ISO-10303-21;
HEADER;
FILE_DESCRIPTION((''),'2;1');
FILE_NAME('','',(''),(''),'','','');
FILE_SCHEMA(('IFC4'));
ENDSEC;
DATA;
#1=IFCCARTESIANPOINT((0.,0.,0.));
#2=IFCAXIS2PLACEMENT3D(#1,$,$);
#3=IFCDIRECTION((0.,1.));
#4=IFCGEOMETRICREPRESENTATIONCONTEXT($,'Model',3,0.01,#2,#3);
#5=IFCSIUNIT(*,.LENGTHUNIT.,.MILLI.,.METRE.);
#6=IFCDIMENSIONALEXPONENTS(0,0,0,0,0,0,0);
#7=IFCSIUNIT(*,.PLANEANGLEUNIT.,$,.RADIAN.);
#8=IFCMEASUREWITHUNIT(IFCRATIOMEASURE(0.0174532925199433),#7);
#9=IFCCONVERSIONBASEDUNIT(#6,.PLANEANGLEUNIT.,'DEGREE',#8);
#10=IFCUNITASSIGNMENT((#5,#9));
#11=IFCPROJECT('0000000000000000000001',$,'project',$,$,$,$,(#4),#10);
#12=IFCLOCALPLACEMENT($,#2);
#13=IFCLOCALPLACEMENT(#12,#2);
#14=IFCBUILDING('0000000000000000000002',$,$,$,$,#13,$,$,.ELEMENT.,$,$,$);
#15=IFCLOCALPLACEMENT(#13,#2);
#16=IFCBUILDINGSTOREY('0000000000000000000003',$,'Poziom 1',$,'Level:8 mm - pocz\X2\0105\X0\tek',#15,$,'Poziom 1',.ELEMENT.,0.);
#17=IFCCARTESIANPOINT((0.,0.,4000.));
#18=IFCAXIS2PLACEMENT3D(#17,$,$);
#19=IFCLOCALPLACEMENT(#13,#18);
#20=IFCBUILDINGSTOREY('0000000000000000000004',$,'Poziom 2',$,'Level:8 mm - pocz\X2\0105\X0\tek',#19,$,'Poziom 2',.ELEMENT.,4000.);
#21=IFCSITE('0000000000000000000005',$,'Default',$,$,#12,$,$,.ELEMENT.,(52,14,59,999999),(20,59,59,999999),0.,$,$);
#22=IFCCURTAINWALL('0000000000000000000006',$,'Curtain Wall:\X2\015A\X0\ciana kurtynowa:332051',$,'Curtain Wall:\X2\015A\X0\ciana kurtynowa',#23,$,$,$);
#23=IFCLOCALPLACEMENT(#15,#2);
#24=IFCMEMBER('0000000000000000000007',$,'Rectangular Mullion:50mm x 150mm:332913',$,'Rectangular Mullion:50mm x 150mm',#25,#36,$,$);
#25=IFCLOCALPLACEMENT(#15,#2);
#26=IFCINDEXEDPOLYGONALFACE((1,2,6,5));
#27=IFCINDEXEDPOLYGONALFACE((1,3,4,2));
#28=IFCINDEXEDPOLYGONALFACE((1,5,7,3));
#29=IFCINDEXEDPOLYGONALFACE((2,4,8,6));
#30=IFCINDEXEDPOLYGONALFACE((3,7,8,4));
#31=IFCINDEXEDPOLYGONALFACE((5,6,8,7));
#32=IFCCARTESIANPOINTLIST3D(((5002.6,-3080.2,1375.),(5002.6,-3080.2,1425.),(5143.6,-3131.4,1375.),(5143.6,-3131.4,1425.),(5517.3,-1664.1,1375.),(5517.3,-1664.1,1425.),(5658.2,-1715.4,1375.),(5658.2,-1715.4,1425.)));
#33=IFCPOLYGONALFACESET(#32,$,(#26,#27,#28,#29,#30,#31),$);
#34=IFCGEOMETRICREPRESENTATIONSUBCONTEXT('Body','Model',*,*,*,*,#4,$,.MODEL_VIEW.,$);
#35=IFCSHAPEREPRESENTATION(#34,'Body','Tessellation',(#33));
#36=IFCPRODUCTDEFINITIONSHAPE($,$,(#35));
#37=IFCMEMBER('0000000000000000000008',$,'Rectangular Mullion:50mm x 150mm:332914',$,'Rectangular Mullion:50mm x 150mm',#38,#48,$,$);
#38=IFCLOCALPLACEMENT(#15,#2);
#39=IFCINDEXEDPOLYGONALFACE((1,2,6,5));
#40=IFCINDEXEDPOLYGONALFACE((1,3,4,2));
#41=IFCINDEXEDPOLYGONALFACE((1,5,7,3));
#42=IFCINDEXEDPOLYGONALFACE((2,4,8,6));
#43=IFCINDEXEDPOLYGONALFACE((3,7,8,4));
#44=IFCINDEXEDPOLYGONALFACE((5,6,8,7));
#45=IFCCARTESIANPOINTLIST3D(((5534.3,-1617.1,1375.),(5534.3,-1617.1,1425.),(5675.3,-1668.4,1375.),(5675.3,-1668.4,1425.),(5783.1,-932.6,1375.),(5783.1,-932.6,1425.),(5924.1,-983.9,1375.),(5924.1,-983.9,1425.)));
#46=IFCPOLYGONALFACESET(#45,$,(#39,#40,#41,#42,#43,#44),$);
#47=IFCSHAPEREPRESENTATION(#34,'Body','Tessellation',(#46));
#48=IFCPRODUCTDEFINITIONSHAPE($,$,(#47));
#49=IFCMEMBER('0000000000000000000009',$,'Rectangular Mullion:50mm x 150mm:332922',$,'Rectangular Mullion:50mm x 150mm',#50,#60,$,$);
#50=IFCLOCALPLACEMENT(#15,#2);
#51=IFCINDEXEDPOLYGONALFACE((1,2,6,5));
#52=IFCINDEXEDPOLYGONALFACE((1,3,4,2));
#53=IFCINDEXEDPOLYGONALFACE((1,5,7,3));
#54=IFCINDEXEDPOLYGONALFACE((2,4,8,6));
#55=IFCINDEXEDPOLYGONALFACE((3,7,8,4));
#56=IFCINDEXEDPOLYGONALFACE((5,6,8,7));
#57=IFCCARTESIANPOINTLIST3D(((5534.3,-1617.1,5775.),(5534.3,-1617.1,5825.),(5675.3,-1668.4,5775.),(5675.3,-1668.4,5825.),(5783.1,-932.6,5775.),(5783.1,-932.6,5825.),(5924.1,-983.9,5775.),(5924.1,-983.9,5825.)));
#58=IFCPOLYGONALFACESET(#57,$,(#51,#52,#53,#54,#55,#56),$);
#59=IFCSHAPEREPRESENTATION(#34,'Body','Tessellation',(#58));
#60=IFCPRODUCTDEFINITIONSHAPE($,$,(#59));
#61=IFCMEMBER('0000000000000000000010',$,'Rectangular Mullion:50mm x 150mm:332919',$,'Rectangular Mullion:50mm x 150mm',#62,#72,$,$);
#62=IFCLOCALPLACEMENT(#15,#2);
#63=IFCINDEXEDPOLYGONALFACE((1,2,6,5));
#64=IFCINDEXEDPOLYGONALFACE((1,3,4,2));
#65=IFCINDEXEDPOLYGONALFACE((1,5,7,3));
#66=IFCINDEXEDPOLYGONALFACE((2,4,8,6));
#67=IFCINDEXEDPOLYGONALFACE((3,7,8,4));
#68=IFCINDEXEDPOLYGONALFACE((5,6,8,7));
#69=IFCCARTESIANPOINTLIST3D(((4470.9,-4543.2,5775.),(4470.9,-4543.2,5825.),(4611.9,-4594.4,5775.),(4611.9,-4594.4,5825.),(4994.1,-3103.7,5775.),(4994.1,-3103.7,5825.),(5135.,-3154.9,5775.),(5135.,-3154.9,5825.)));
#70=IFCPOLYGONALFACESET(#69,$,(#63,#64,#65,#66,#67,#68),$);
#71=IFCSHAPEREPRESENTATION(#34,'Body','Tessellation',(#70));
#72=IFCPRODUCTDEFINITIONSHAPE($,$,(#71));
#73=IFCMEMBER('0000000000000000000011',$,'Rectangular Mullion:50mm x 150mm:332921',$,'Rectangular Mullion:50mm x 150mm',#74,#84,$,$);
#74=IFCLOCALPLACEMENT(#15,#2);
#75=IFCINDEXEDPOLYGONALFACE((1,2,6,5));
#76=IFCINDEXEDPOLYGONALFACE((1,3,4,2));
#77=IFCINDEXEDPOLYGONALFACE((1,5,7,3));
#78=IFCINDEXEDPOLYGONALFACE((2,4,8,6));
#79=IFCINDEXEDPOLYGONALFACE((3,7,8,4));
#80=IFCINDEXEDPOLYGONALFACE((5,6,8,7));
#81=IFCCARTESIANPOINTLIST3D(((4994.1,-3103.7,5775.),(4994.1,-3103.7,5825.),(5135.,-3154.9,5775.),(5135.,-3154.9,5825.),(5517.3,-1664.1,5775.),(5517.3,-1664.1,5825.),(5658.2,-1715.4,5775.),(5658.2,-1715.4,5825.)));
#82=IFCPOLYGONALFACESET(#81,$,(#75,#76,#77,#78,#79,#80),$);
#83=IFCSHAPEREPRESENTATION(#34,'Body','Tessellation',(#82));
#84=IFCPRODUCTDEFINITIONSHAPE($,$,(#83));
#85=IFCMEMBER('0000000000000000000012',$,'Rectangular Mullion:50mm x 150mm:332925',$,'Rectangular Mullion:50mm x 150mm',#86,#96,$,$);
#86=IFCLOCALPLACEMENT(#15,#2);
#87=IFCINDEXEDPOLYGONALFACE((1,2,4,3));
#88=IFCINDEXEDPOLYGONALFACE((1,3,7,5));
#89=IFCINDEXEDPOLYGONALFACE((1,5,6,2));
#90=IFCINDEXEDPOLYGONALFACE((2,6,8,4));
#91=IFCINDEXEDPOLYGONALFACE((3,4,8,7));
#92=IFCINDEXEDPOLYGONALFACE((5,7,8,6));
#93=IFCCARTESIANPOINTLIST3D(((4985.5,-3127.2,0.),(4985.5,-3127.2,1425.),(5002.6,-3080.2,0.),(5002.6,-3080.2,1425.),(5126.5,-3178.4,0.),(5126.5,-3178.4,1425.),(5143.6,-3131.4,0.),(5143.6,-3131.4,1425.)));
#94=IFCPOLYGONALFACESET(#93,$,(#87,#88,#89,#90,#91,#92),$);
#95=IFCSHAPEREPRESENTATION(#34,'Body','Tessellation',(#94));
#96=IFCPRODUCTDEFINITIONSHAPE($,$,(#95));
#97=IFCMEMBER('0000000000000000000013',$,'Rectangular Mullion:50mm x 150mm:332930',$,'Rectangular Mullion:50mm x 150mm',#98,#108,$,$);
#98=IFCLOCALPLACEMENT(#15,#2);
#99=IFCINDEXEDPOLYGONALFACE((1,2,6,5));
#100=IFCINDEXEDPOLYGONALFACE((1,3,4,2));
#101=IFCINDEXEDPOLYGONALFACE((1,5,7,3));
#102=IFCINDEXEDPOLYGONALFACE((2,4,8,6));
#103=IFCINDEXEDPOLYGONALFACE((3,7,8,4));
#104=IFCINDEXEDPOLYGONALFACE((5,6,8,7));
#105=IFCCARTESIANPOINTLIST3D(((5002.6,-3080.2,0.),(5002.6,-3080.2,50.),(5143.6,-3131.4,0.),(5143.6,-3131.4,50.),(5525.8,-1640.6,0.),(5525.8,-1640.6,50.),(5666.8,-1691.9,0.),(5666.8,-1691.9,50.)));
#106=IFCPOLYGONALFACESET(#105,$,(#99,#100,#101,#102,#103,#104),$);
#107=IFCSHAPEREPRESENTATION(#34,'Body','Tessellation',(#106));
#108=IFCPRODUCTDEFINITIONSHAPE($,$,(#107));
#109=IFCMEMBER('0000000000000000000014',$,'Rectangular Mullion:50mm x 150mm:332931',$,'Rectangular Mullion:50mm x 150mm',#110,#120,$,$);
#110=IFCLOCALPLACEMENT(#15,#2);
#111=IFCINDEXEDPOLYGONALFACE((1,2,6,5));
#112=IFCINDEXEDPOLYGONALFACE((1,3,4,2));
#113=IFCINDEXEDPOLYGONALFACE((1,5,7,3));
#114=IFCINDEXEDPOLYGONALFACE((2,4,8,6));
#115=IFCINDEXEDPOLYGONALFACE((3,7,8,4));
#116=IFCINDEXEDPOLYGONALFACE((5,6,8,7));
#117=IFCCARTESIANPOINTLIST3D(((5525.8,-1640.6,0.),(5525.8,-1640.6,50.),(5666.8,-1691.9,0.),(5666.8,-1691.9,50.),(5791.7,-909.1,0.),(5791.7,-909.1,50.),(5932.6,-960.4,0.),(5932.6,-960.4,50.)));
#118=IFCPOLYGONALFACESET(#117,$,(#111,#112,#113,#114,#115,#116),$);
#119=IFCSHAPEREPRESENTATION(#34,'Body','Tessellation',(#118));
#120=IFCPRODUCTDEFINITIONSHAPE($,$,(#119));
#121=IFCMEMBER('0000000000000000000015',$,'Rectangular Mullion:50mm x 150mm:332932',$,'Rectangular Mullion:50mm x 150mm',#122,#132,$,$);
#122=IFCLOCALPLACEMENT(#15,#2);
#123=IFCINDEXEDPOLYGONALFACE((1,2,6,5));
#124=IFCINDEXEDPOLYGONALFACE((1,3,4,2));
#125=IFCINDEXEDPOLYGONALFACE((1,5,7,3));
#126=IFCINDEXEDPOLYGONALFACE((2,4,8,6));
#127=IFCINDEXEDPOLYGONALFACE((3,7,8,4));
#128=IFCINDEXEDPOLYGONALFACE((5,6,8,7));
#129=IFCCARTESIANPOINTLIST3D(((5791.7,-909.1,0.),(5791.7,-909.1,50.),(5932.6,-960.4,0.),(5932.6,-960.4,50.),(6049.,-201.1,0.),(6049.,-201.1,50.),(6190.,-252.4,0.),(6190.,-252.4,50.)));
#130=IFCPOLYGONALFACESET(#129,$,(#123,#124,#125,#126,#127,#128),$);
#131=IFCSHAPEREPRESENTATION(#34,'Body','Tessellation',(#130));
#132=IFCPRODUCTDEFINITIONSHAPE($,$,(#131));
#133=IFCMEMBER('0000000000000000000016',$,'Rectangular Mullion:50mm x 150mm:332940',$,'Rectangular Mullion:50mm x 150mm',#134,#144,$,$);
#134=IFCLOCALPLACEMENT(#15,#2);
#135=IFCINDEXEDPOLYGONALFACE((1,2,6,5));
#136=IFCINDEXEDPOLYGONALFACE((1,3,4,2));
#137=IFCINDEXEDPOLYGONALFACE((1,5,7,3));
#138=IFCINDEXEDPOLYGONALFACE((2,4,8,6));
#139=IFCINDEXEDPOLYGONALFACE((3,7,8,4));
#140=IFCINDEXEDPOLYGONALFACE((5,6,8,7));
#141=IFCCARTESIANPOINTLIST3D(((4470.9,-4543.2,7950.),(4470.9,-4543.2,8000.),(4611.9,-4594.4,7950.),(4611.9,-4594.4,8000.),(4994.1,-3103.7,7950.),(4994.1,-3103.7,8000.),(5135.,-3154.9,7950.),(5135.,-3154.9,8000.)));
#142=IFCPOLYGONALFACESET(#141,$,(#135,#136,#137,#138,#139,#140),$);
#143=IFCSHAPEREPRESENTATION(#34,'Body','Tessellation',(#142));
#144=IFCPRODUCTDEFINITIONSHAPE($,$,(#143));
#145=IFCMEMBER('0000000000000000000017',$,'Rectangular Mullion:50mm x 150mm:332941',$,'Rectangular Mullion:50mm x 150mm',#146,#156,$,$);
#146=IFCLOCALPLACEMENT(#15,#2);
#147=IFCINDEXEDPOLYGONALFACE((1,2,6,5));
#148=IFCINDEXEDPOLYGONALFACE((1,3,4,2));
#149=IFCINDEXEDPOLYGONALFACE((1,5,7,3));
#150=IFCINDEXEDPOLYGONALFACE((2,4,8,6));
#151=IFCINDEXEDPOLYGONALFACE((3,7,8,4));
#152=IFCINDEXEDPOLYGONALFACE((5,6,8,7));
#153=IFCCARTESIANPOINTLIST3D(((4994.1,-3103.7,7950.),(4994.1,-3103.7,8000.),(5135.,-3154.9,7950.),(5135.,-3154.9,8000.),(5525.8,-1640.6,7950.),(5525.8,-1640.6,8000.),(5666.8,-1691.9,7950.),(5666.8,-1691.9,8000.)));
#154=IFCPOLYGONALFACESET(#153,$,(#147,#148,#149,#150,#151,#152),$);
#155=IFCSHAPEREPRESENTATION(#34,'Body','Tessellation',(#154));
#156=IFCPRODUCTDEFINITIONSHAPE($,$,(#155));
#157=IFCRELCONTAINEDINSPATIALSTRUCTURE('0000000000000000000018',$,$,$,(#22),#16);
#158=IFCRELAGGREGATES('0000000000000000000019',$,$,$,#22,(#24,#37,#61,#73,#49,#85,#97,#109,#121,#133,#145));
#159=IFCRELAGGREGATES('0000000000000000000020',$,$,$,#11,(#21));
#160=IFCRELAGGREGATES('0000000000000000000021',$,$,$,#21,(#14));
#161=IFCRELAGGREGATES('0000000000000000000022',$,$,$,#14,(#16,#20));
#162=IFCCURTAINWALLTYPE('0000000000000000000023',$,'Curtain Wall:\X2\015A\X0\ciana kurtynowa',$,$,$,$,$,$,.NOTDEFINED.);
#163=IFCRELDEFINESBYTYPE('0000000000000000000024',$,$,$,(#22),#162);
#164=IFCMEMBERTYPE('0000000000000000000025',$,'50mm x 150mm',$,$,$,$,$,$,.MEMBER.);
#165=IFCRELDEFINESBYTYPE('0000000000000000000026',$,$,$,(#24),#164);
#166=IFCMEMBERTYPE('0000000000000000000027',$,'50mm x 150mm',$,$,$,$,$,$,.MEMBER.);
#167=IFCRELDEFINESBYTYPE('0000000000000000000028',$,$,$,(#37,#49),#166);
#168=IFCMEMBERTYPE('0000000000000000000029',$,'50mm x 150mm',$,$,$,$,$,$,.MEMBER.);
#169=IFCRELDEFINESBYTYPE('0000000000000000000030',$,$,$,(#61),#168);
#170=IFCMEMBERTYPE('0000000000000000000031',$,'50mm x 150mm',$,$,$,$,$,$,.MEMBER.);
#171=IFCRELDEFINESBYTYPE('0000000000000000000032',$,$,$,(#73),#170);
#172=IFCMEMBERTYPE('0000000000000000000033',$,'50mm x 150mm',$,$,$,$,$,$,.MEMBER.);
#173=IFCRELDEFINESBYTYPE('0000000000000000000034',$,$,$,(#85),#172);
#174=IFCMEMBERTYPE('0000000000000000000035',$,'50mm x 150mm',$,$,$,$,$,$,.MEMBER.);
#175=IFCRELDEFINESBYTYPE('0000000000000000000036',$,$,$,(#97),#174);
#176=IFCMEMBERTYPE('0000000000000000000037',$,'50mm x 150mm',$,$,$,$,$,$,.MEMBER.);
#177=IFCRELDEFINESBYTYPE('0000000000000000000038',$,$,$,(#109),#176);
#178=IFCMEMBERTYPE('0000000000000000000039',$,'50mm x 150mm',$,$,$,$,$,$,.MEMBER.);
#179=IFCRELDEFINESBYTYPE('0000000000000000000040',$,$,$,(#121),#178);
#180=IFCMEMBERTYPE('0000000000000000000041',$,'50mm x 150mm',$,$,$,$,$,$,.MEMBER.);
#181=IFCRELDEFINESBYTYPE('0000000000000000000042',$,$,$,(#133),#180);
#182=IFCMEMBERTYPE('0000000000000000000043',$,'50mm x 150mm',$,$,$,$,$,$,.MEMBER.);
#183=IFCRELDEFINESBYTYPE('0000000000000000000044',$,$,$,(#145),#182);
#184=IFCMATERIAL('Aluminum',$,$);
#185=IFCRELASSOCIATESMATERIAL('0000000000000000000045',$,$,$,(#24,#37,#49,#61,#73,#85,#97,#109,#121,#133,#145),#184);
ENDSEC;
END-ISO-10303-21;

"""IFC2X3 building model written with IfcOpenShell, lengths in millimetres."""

from ifc_helpers import new_model, entity, si_unit, converted_unit, direction, frame, origin, origin_2d_with_axis, place, context, subcontext, project, spatial, rectangle, extrude, source, transform, mapped, material, type_object, type_shapes, element, aggregate, save


model = new_model("IFC2X3")

# Units and contexts
model_context = context("Model", 3, precision=0.01, world=origin(), true_north=direction((0.0, 1.0)))
body_context = subcontext(model_context, "Body", "Model", "MODEL_VIEW")
ifc_project = project(units=[si_unit("LENGTHUNIT", "METRE", prefix="MILLI"), converted_unit("PLANEANGLEUNIT", "DEGREE", entity("IfcRatioMeasure", 0.0174532925199433), si_unit("PLANEANGLEUNIT", "RADIAN"), dimensions=[0, 0, 0, 0, 0, 0, 0])], contexts=[model_context])

# Site, building, storey
site_placement = place(None, origin())
site = spatial("IfcSite", under=ifc_project, at=site_placement, Name="Default", CompositionType="ELEMENT", RefLatitude=(52, 14, 59, 999999), RefLongitude=(20, 59, 59, 999999), RefElevation=0.0)
building_placement = place(site_placement, origin())
building = spatial("IfcBuilding", under=site, at=building_placement, CompositionType="ELEMENT")
storey_1_placement = place(building_placement, origin())
storey_1 = spatial("IfcBuildingStorey", under=building, at=storey_1_placement, Name="Poziom 1", ObjectType="Level:8 mm - początek", LongName="Poziom 1", CompositionType="ELEMENT", Elevation=0.0)

# Curtain wall, members
curtain_wall_type = type_object("IfcCurtainWallType", Name="Curtain Wall:Ściana kurtynowa", PredefinedType="NOTDEFINED")
curtain_wall_placement = place(storey_1_placement, origin())
curtain_wall = element("IfcCurtainWall", 1, at=curtain_wall_placement, inside=storey_1, type_object=curtain_wall_type, Name="Curtain Wall:Ściana kurtynowa:332051", ObjectType="Curtain Wall:Ściana kurtynowa")
ifc_material_1 = material(Name="Aluminum")
member_type_1 = type_object("IfcMemberType", Name="50mm x 150mm", PredefinedType="MEMBER")
shared_shape_1 = source(origin(), body_context, "Body", "SweptSolid", [
    extrude(rectangle(XDim=150.0, YDim=50.0, at=origin_2d_with_axis()), frame((0.0, 0.0, -1506.6), z_axis=(0.0, 0.0, 1.0), x_axis=(0.0, -1.0, 0.0)), (0.0, 0.0, 1.0), 1506.6),
])
type_shapes(member_type_1, [shared_shape_1])
member_1_placement = place(storey_1_placement, frame((5587.7, -1689.8, 1400.0), z_axis=(0.341586, 0.939851, 0.0), x_axis=(0.0, 0.0, 1.0)))
member_1 = element("IfcMember", 2, at=member_1_placement, type_object=member_type_1, material=ifc_material_1, Name="Rectangular Mullion:50mm x 150mm:332913", ObjectType="Rectangular Mullion:50mm x 150mm", context=body_context, shape_type="MappedRepresentation", body=[
    mapped(shared_shape_1, transform((0.0, 0.0, 0.0), scale=1.0)),
])
member_type_2 = type_object("IfcMemberType", Name="50mm x 150mm", PredefinedType="MEMBER")
shared_shape_2 = source(origin(), body_context, "Body", "SweptSolid", [
    extrude(rectangle(XDim=150.0, YDim=50.0, at=origin_2d_with_axis()), frame((0.0, 0.0, -728.3), z_axis=(0.0, 0.0, 1.0), x_axis=(0.0, -1.0, 0.0)), (0.0, 0.0, 1.0), 728.3),
])
type_shapes(member_type_2, [shared_shape_2])
member_2_placement = place(storey_1_placement, frame((5853.6, -958.2, 1400.0), z_axis=(0.341586, 0.939851, 0.0), x_axis=(0.0, 0.0, 1.0)))
member_2 = element("IfcMember", 3, at=member_2_placement, type_object=member_type_2, material=ifc_material_1, Name="Rectangular Mullion:50mm x 150mm:332914", ObjectType="Rectangular Mullion:50mm x 150mm", context=body_context, shape_type="MappedRepresentation", body=[
    mapped(shared_shape_2, transform((0.0, 0.0, 0.0), scale=1.0)),
])
member_3_placement = place(storey_1_placement, frame((5853.6, -958.2, 5800.0), z_axis=(0.341586, 0.939851, 0.0), x_axis=(0.0, 0.0, 1.0)))
member_3 = element("IfcMember", 4, at=member_3_placement, type_object=member_type_2, material=ifc_material_1, Name="Rectangular Mullion:50mm x 150mm:332922", ObjectType="Rectangular Mullion:50mm x 150mm", context=body_context, shape_type="MappedRepresentation", body=[
    mapped(shared_shape_2, transform((0.0, 0.0, 0.0), scale=1.0)),
])
member_type_3 = type_object("IfcMemberType", Name="50mm x 150mm", PredefinedType="MEMBER")
shared_shape_3 = source(origin(), body_context, "Body", "SweptSolid", [
    extrude(rectangle(XDim=150.0, YDim=50.0, at=origin_2d_with_axis()), frame((0.0, 0.0, -1531.6), z_axis=(0.0, 0.0, 1.0), x_axis=(0.0, -1.0, 0.0)), (0.0, 0.0, 1.0), 1531.6),
])
type_shapes(member_type_3, [shared_shape_3])
member_4_placement = place(storey_1_placement, frame((5064.6, -3129.3, 5800.0), z_axis=(0.341586, 0.939851, 0.0), x_axis=(0.0, 0.0, 1.0)))
member_4 = element("IfcMember", 5, at=member_4_placement, type_object=member_type_3, material=ifc_material_1, Name="Rectangular Mullion:50mm x 150mm:332919", ObjectType="Rectangular Mullion:50mm x 150mm", context=body_context, shape_type="MappedRepresentation", body=[
    mapped(shared_shape_3, transform((0.0, 0.0, 0.0), scale=1.0)),
])
member_type_4 = type_object("IfcMemberType", Name="50mm x 150mm", PredefinedType="MEMBER")
shared_shape_4 = source(origin(), body_context, "Body", "SweptSolid", [
    extrude(rectangle(XDim=150.0, YDim=50.0, at=origin_2d_with_axis()), frame((0.0, 0.0, -1531.6), z_axis=(0.0, 0.0, 1.0), x_axis=(0.0, -1.0, 0.0)), (0.0, 0.0, 1.0), 1531.6),
])
type_shapes(member_type_4, [shared_shape_4])
member_5_placement = place(storey_1_placement, frame((5587.7, -1689.8, 5800.0), z_axis=(0.341586, 0.939851, 0.0), x_axis=(0.0, 0.0, 1.0)))
member_5 = element("IfcMember", 6, at=member_5_placement, type_object=member_type_4, material=ifc_material_1, Name="Rectangular Mullion:50mm x 150mm:332921", ObjectType="Rectangular Mullion:50mm x 150mm", context=body_context, shape_type="MappedRepresentation", body=[
    mapped(shared_shape_4, transform((0.0, 0.0, 0.0), scale=1.0)),
])
member_type_5 = type_object("IfcMemberType", Name="50mm x 150mm", PredefinedType="MEMBER")
shared_shape_5 = source(origin(), body_context, "Body", "SweptSolid", [
    extrude(rectangle(XDim=150.0, YDim=50.0, at=origin_2d_with_axis()), frame((0.0, 0.0, -1425.0), z_axis=(0.0, 0.0, 1.0), x_axis=(0.0, -1.0, 0.0)), (0.0, 0.0, 1.0), 1425.0),
])
type_shapes(member_type_5, [shared_shape_5])
member_6_placement = place(storey_1_placement, frame((5064.6, -3129.3, 0.0), z_axis=(0.0, 0.0, -1.0), x_axis=(0.341586, 0.939851, 0.0)))
member_6 = element("IfcMember", 7, at=member_6_placement, type_object=member_type_5, material=ifc_material_1, Name="Rectangular Mullion:50mm x 150mm:332925", ObjectType="Rectangular Mullion:50mm x 150mm", context=body_context, shape_type="MappedRepresentation", body=[
    mapped(shared_shape_5, transform((0.0, 0.0, 0.0), scale=1.0)),
])
member_type_6 = type_object("IfcMemberType", Name="50mm x 150mm", PredefinedType="MEMBER")
shared_shape_6 = source(origin(), body_context, "Body", "SweptSolid", [
    extrude(rectangle(XDim=150.0, YDim=50.0, at=origin_2d_with_axis()), frame((-25.0, 0.0, -1531.6), z_axis=(0.0, 0.0, 1.0), x_axis=(0.0, -1.0, 0.0)), (0.0, 0.0, 1.0), 1531.6),
])
type_shapes(member_type_6, [shared_shape_6])
member_7_placement = place(storey_1_placement, frame((5073.1, -3105.8, 0.0), z_axis=(-0.341586, -0.939851, 0.0), x_axis=(0.0, 0.0, -1.0)))
member_7 = element("IfcMember", 8, at=member_7_placement, type_object=member_type_6, material=ifc_material_1, Name="Rectangular Mullion:50mm x 150mm:332930", ObjectType="Rectangular Mullion:50mm x 150mm", context=body_context, shape_type="MappedRepresentation", body=[
    mapped(shared_shape_6, transform((0.0, 0.0, 0.0), scale=1.0)),
])
member_type_7 = type_object("IfcMemberType", Name="50mm x 150mm", PredefinedType="MEMBER")
shared_shape_7 = source(origin(), body_context, "Body", "SweptSolid", [
    extrude(rectangle(XDim=150.0, YDim=50.0, at=origin_2d_with_axis()), frame((-25.0, 0.0, -778.3), z_axis=(0.0, 0.0, 1.0), x_axis=(0.0, -1.0, 0.0)), (0.0, 0.0, 1.0), 778.3),
])
type_shapes(member_type_7, [shared_shape_7])
member_8_placement = place(storey_1_placement, frame((5596.3, -1666.3, 0.0), z_axis=(-0.341586, -0.939851, 0.0), x_axis=(0.0, 0.0, -1.0)))
member_8 = element("IfcMember", 9, at=member_8_placement, type_object=member_type_7, material=ifc_material_1, Name="Rectangular Mullion:50mm x 150mm:332931", ObjectType="Rectangular Mullion:50mm x 150mm", context=body_context, shape_type="MappedRepresentation", body=[
    mapped(shared_shape_7, transform((0.0, 0.0, 0.0), scale=1.0)),
])
member_type_8 = type_object("IfcMemberType", Name="50mm x 150mm", PredefinedType="MEMBER")
shared_shape_8 = source(origin(), body_context, "Body", "SweptSolid", [
    extrude(rectangle(XDim=150.0, YDim=50.0, at=origin_2d_with_axis()), frame((-25.0, 0.0, -753.3), z_axis=(0.0, 0.0, 1.0), x_axis=(0.0, -1.0, 0.0)), (0.0, 0.0, 1.0), 753.3),
])
type_shapes(member_type_8, [shared_shape_8])
member_9_placement = place(storey_1_placement, frame((5862.1, -934.8, 0.0), z_axis=(-0.341586, -0.939851, 0.0), x_axis=(0.0, 0.0, -1.0)))
member_9 = element("IfcMember", 10, at=member_9_placement, type_object=member_type_8, material=ifc_material_1, Name="Rectangular Mullion:50mm x 150mm:332932", ObjectType="Rectangular Mullion:50mm x 150mm", context=body_context, shape_type="MappedRepresentation", body=[
    mapped(shared_shape_8, transform((0.0, 0.0, 0.0), scale=1.0)),
])
member_type_9 = type_object("IfcMemberType", Name="50mm x 150mm", PredefinedType="MEMBER")
shared_shape_9 = source(origin(), body_context, "Body", "SweptSolid", [
    extrude(rectangle(XDim=150.0, YDim=50.0, at=origin_2d_with_axis()), frame((-25.0, 0.0, -1531.6), z_axis=(0.0, 0.0, 1.0), x_axis=(0.0, -1.0, 0.0)), (0.0, 0.0, 1.0), 1531.6),
])
type_shapes(member_type_9, [shared_shape_9])
member_10_placement = place(storey_1_placement, frame((5064.6, -3129.3, 8000.0), z_axis=(0.341586, 0.939851, 0.0), x_axis=(0.0, 0.0, 1.0)))
member_10 = element("IfcMember", 11, at=member_10_placement, type_object=member_type_9, material=ifc_material_1, Name="Rectangular Mullion:50mm x 150mm:332940", ObjectType="Rectangular Mullion:50mm x 150mm", context=body_context, shape_type="MappedRepresentation", body=[
    mapped(shared_shape_9, transform((0.0, 0.0, 0.0), scale=1.0)),
])
member_type_10 = type_object("IfcMemberType", Name="50mm x 150mm", PredefinedType="MEMBER")
shared_shape_10 = source(origin(), body_context, "Body", "SweptSolid", [
    extrude(rectangle(XDim=150.0, YDim=50.0, at=origin_2d_with_axis()), frame((-25.0, 0.0, -1556.6), z_axis=(0.0, 0.0, 1.0), x_axis=(0.0, -1.0, 0.0)), (0.0, 0.0, 1.0), 1556.6),
])
type_shapes(member_type_10, [shared_shape_10])
member_11_placement = place(storey_1_placement, frame((5596.3, -1666.3, 8000.0), z_axis=(0.341586, 0.939851, 0.0), x_axis=(0.0, 0.0, 1.0)))
member_11 = element("IfcMember", 12, at=member_11_placement, type_object=member_type_10, material=ifc_material_1, Name="Rectangular Mullion:50mm x 150mm:332941", ObjectType="Rectangular Mullion:50mm x 150mm", context=body_context, shape_type="MappedRepresentation", body=[
    mapped(shared_shape_10, transform((0.0, 0.0, 0.0), scale=1.0)),
])

aggregate(curtain_wall, [member_1, member_2, member_4, member_5, member_3, member_6, member_7, member_8, member_9, member_10, member_11])

# Shared definitions
storey_2_placement = place(building_placement, frame((0.0, 0.0, 4000.0)))
storey_2 = spatial("IfcBuildingStorey", under=building, at=storey_2_placement, Name="Poziom 2", ObjectType="Level:8 mm - początek", LongName="Poziom 2", CompositionType="ELEMENT", Elevation=4000.0)

save(model, "model.ifc")
